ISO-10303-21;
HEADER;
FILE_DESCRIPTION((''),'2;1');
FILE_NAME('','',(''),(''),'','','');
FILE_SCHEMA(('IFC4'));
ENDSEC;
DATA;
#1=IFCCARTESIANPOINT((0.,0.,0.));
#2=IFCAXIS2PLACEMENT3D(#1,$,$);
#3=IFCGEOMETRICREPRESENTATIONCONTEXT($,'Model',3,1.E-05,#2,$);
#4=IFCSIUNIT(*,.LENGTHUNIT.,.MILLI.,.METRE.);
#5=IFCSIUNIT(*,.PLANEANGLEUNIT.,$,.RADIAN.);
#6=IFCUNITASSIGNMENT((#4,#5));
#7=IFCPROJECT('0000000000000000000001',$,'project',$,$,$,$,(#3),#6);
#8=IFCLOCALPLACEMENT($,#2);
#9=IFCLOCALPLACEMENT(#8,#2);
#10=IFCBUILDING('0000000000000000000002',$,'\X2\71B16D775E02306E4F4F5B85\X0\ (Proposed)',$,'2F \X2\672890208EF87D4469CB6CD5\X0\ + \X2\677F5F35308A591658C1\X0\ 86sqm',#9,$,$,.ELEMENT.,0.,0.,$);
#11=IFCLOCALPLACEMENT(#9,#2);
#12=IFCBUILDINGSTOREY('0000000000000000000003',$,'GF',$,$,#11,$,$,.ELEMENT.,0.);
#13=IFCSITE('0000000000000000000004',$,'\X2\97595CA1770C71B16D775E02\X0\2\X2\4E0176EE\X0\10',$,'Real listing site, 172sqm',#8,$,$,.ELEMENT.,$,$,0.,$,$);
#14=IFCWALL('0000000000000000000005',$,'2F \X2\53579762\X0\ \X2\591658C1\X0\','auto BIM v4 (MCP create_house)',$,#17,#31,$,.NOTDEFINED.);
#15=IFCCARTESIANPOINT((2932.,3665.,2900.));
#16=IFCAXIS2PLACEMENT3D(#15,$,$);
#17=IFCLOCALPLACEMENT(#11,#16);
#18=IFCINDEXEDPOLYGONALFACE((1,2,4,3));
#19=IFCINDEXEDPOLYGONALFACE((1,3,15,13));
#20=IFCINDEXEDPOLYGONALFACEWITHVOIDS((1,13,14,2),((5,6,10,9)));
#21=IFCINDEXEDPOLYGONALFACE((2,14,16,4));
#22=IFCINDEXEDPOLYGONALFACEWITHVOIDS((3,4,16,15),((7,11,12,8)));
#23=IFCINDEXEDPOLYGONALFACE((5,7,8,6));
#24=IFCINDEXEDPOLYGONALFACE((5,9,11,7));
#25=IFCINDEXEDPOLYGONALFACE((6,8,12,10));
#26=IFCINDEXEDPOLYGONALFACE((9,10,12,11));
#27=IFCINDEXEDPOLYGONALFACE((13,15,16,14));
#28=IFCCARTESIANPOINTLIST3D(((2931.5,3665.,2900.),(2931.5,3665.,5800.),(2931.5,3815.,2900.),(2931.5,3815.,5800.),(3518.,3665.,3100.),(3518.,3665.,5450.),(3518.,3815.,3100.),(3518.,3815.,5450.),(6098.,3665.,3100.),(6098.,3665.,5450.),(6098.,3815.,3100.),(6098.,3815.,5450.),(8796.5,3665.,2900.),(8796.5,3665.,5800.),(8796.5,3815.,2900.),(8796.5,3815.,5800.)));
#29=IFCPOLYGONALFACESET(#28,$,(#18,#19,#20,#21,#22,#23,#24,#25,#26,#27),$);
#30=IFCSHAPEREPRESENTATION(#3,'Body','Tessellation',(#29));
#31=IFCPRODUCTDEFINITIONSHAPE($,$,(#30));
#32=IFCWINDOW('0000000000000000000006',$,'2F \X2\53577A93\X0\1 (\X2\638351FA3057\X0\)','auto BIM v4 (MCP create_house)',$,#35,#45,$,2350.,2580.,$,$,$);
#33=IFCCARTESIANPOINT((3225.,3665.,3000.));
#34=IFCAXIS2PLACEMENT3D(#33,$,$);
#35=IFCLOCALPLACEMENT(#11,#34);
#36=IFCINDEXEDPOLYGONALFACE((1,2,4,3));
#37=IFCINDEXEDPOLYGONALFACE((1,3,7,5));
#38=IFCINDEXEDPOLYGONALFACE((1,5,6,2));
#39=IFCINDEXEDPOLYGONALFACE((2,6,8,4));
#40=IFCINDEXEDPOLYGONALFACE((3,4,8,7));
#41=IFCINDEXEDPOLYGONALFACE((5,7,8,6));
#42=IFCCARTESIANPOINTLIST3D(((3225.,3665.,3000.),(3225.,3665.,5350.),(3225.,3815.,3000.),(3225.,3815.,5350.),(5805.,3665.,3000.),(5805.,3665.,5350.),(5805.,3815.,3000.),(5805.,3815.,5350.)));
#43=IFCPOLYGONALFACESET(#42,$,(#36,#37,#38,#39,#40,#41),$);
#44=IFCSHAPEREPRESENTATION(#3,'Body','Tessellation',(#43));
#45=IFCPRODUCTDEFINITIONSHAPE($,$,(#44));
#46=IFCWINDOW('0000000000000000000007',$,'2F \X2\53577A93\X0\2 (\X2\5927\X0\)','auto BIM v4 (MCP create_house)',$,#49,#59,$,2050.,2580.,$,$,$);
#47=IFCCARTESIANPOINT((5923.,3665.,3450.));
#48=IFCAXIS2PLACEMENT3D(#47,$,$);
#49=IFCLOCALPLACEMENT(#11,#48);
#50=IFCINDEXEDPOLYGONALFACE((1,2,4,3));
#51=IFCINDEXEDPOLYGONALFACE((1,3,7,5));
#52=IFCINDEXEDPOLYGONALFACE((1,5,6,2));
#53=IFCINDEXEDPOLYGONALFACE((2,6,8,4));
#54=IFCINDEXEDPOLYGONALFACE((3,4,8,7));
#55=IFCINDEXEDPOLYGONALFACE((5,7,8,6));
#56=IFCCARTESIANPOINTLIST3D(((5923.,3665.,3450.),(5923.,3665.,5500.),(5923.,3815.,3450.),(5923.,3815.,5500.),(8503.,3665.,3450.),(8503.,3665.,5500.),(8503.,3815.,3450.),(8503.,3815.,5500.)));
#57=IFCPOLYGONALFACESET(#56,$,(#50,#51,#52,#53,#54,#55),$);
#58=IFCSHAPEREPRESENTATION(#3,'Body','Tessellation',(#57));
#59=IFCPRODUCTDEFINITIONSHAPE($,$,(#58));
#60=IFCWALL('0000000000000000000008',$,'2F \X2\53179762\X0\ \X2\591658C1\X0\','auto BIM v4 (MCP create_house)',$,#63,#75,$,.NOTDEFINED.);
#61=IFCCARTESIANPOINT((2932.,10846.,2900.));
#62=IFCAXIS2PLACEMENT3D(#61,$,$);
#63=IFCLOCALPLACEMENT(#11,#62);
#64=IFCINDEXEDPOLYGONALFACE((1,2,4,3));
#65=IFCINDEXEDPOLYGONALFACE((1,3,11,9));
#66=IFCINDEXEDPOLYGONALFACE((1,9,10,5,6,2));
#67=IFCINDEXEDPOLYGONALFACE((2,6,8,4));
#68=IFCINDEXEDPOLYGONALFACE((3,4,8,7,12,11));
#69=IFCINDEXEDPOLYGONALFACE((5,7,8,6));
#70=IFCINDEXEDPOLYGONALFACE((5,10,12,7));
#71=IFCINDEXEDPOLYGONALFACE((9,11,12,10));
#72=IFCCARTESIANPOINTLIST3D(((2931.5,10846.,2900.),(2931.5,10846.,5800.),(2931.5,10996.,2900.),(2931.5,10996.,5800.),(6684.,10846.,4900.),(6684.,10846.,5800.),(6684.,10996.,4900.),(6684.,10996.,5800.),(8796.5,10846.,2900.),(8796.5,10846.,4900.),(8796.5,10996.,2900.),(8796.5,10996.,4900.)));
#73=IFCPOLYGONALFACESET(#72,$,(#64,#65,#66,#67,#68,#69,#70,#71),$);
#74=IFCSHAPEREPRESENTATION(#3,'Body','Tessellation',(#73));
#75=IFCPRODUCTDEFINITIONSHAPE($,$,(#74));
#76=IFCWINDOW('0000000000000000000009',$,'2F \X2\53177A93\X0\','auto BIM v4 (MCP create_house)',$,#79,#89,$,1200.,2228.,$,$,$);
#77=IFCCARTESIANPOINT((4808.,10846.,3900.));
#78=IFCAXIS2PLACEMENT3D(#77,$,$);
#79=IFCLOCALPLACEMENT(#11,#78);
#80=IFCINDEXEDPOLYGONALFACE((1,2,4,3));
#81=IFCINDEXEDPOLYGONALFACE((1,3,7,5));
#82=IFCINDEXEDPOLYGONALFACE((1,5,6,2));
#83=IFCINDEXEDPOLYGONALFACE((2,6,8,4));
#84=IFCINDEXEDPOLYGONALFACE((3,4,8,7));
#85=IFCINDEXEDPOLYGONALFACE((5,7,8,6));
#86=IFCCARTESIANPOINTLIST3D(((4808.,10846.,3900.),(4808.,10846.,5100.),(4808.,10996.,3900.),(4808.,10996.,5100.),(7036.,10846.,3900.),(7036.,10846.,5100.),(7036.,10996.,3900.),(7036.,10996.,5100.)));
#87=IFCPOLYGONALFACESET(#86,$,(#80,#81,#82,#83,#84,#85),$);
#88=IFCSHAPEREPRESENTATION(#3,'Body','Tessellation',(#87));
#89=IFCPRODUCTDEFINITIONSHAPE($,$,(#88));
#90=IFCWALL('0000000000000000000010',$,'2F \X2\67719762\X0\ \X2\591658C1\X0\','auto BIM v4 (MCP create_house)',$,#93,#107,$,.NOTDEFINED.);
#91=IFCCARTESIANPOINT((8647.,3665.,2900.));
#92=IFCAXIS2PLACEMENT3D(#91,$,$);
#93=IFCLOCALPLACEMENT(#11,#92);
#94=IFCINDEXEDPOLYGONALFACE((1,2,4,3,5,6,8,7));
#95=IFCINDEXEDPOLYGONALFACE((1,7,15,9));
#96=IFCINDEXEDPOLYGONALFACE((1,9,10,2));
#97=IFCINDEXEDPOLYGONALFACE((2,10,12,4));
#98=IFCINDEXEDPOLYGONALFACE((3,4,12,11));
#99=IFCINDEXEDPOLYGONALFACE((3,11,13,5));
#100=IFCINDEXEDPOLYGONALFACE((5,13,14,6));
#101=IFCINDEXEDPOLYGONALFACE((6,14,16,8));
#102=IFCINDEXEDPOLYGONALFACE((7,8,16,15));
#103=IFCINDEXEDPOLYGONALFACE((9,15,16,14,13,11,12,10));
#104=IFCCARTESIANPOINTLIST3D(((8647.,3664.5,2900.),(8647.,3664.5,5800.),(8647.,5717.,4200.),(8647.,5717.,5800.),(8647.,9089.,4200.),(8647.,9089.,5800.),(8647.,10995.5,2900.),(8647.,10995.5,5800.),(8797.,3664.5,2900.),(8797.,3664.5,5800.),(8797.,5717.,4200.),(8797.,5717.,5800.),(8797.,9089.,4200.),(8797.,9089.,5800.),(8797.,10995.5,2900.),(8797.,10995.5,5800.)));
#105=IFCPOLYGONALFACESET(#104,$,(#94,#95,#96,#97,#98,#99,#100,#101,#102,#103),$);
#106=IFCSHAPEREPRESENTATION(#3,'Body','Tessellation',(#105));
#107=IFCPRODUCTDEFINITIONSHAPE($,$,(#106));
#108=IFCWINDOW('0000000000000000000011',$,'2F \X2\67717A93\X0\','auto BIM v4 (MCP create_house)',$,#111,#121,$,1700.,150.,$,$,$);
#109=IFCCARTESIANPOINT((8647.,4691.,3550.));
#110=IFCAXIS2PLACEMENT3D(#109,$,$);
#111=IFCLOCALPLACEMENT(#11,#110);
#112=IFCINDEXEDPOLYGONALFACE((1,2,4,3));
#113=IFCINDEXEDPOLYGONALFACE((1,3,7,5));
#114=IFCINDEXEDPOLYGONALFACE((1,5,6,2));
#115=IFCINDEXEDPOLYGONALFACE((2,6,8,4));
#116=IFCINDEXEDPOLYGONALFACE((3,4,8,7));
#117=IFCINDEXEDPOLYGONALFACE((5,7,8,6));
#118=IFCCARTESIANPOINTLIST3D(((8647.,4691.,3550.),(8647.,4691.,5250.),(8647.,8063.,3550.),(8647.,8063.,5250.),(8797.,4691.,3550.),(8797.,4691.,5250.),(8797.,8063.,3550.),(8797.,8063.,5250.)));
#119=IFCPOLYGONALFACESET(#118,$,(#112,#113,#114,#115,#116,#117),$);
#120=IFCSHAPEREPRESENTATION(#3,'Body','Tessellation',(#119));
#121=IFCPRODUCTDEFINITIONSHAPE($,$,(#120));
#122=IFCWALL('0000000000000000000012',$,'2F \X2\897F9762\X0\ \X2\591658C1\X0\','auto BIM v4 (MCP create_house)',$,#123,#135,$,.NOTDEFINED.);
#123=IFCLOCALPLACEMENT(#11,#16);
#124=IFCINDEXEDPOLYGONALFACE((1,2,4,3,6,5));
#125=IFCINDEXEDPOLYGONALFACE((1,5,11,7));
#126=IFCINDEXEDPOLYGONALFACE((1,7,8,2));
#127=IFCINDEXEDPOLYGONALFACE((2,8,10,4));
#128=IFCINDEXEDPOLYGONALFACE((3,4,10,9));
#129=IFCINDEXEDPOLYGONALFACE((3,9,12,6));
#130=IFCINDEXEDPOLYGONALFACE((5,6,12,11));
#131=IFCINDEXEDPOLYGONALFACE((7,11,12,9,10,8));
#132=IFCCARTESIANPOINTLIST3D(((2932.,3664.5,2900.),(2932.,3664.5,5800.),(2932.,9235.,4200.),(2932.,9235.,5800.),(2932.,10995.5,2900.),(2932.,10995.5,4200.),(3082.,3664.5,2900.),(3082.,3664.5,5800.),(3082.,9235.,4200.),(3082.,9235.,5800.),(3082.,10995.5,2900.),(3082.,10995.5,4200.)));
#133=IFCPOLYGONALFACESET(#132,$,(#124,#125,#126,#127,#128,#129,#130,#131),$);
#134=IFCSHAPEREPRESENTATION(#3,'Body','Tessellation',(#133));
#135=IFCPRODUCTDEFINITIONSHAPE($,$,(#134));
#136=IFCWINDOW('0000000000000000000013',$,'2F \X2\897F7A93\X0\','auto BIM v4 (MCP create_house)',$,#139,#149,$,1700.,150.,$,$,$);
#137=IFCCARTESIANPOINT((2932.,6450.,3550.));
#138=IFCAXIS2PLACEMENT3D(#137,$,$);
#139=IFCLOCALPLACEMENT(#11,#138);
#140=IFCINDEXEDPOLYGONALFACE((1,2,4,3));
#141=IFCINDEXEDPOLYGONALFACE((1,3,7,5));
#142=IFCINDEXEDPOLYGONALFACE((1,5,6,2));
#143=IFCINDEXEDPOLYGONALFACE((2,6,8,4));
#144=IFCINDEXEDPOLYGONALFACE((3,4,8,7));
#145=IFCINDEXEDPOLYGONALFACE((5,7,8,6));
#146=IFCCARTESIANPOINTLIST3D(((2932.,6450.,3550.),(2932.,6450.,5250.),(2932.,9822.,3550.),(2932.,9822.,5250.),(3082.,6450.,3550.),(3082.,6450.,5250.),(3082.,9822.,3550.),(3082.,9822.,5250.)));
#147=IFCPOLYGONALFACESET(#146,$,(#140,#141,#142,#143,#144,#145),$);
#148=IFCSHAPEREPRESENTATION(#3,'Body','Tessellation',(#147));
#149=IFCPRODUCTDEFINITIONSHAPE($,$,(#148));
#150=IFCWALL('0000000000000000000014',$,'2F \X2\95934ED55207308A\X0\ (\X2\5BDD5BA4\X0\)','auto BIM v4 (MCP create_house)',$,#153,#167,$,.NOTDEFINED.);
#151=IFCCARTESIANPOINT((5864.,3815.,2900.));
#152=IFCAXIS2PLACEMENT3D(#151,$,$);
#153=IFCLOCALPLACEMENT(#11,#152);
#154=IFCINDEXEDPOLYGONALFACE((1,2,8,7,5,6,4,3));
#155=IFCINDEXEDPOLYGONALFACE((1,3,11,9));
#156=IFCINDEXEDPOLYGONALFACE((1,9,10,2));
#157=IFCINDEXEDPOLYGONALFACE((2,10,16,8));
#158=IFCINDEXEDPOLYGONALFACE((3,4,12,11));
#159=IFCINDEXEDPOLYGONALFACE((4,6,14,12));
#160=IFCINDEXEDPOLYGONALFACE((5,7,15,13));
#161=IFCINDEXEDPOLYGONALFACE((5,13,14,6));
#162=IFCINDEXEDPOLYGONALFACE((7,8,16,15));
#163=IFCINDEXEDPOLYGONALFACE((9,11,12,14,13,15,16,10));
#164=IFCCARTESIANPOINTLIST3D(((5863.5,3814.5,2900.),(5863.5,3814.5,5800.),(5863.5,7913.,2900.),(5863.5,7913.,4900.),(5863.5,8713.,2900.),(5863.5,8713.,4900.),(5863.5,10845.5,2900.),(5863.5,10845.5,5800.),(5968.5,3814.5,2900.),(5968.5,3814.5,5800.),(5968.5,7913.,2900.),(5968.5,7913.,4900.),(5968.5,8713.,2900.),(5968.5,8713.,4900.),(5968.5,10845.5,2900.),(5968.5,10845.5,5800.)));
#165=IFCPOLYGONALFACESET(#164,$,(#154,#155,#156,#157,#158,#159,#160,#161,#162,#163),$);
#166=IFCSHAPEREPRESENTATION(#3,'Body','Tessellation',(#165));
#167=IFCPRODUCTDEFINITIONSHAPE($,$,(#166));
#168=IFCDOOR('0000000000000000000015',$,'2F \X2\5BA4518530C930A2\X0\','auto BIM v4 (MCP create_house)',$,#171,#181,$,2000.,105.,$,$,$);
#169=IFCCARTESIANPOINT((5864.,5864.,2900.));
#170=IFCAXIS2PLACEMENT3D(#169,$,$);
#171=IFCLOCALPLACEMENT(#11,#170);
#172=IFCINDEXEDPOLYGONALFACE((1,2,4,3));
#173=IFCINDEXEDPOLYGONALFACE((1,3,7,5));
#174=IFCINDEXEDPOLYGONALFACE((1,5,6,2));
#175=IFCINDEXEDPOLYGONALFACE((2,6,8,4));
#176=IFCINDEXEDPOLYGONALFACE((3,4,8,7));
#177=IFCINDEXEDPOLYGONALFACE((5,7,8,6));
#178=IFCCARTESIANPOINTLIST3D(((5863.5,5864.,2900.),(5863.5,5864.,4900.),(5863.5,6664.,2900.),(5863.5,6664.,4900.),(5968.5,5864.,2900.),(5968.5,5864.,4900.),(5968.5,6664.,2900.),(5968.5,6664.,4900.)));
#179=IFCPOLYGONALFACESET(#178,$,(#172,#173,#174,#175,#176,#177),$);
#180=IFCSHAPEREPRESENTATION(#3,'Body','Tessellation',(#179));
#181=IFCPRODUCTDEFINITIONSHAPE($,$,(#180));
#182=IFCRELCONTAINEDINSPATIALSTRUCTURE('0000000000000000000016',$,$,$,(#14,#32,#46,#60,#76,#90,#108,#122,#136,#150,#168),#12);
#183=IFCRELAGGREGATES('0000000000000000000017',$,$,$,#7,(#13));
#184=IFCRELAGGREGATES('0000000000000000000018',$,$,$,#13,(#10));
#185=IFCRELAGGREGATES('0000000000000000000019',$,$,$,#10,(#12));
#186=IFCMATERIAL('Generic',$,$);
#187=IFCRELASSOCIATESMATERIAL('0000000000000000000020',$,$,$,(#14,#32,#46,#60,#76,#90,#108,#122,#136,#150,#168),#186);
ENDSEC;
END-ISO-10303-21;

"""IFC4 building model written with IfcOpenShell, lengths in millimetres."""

from ifc_helpers import new_model, si_unit, frame, frame_2d, origin, place, context, project, spatial, rectangle, extrude, material, element, fill, save


model = new_model("IFC4")

# Units and contexts
model_context = context("Model", 3, precision=1e-05, world=origin())
ifc_project = project(units=[si_unit("LENGTHUNIT", "METRE", prefix="MILLI"), si_unit("PLANEANGLEUNIT", "RADIAN")], contexts=[model_context])

# Site, building, storey
site_placement = place(None, origin())
site = spatial("IfcSite", under=ifc_project, at=site_placement, Name="静岡県熱海市2丁目10", ObjectType="Real listing site, 172sqm", CompositionType="ELEMENT", RefElevation=0.0)
building_placement = place(site_placement, origin())
building = spatial("IfcBuilding", under=site, at=building_placement, Name="熱海市の住宅 (Proposed)", ObjectType="2F 木造軸組構法 + 板張り外壁 86sqm", CompositionType="ELEMENT", ElevationOfRefHeight=0.0, ElevationOfTerrain=0.0)
storey_placement = place(building_placement, origin())
storey = spatial("IfcBuildingStorey", under=building, at=storey_placement, Name="GF", CompositionType="ELEMENT", Elevation=0.0)

# Shared definitions
ifc_material = material(Name="Generic")

# Wall, openings, windows
wall_1_placement = place(storey_placement, frame((2932.0, 3665.0, 2900.0)))
wall_1 = element("IfcWall", 1, at=wall_1_placement, inside=storey, material=ifc_material, Name="2F 南面 外壁", Description="auto BIM v4 (MCP create_house)", PredefinedType="NOTDEFINED", context=model_context, shape_type="SweptSolid", body=[
    extrude(rectangle(XDim=5865.0, YDim=150.0, at=frame_2d((2932.0, 75.0))), frame((2932.0, 3665.0, 2900.0)), (0.0, 0.0, 1.0), 2900.0),
])
opening_1_placement = place(storey_placement, frame((3225.0, 3665.0, 3000.0)))
opening_1 = element("IfcOpeningElement", 2, at=opening_1_placement, cuts=wall_1, PredefinedType="NOTDEFINED", context=model_context, shape_type="SweptSolid", body=[
    extrude(rectangle(XDim=2580.0, YDim=150.0, at=frame_2d((1290.0, 75.0))), frame((3225.0, 3665.0, 3000.0)), (0.0, 0.0, 1.0), 2350.0),
])
opening_2_placement = place(storey_placement, frame((5923.0, 3665.0, 3450.0)))
opening_2 = element("IfcOpeningElement", 3, at=opening_2_placement, cuts=wall_1, PredefinedType="NOTDEFINED", context=model_context, shape_type="SweptSolid", body=[
    extrude(rectangle(XDim=2580.0, YDim=150.0, at=frame_2d((1290.0, 75.0))), frame((5923.0, 3665.0, 3450.0)), (0.0, 0.0, 1.0), 2050.0),
])
window_1_placement = place(storey_placement, frame((3225.0, 3665.0, 3000.0)))
window_1 = element("IfcWindow", 4, at=window_1_placement, inside=storey, material=ifc_material, Name="2F 南窓1 (掃出し)", Description="auto BIM v4 (MCP create_house)", OverallHeight=2350.0, OverallWidth=2580.0, context=model_context, shape_type="SweptSolid", body=[
    extrude(rectangle(XDim=2580.0, YDim=150.0, at=frame_2d((1290.0, 75.0))), frame((3225.0, 3665.0, 3000.0)), (0.0, 0.0, 1.0), 2350.0),
])
fill(opening_1, window_1)
window_2_placement = place(storey_placement, frame((5923.0, 3665.0, 3450.0)))
window_2 = element("IfcWindow", 5, at=window_2_placement, inside=storey, material=ifc_material, Name="2F 南窓2 (大)", Description="auto BIM v4 (MCP create_house)", OverallHeight=2050.0, OverallWidth=2580.0, context=model_context, shape_type="SweptSolid", body=[
    extrude(rectangle(XDim=2580.0, YDim=150.0, at=frame_2d((1290.0, 75.0))), frame((5923.0, 3665.0, 3450.0)), (0.0, 0.0, 1.0), 2050.0),
])
fill(opening_2, window_2)

# Walls, openings, windows
wall_2_placement = place(storey_placement, frame((2932.0, 10846.0, 2900.0)))
wall_2 = element("IfcWall", 6, at=wall_2_placement, inside=storey, material=ifc_material, Name="2F 北面 外壁", Description="auto BIM v4 (MCP create_house)", PredefinedType="NOTDEFINED", context=model_context, shape_type="SweptSolid", body=[
    extrude(rectangle(XDim=5865.0, YDim=150.0, at=frame_2d((2932.0, 75.0))), frame((2932.0, 10846.0, 2900.0)), (0.0, 0.0, 1.0), 2900.0),
])
opening_3_placement = place(storey_placement, frame((4808.0, 10846.0, 3900.0)))
opening_3 = element("IfcOpeningElement", 7, at=opening_3_placement, cuts=wall_2, PredefinedType="NOTDEFINED", context=model_context, shape_type="SweptSolid", body=[
    extrude(rectangle(XDim=2228.0, YDim=150.0, at=frame_2d((1114.0, 75.0))), frame((4808.0, 10846.0, 3900.0)), (0.0, 0.0, 1.0), 1200.0),
])
window_3_placement = place(storey_placement, frame((4808.0, 10846.0, 3900.0)))
window_3 = element("IfcWindow", 8, at=window_3_placement, inside=storey, material=ifc_material, Name="2F 北窓", Description="auto BIM v4 (MCP create_house)", OverallHeight=1200.0, OverallWidth=2228.0, context=model_context, shape_type="SweptSolid", body=[
    extrude(rectangle(XDim=2228.0, YDim=150.0, at=frame_2d((1114.0, 75.0))), frame((4808.0, 10846.0, 3900.0)), (0.0, 0.0, 1.0), 1200.0),
])
fill(opening_3, window_3)
wall_3_placement = place(storey_placement, frame((8647.0, 3665.0, 2900.0)))
wall_3 = element("IfcWall", 9, at=wall_3_placement, inside=storey, material=ifc_material, Name="2F 東面 外壁", Description="auto BIM v4 (MCP create_house)", PredefinedType="NOTDEFINED", context=model_context, shape_type="SweptSolid", body=[
    extrude(rectangle(XDim=150.0, YDim=7331.0, at=frame_2d((75.0, 3665.0))), frame((8647.0, 3665.0, 2900.0)), (0.0, 0.0, 1.0), 2900.0),
])
opening_4_placement = place(storey_placement, frame((8647.0, 4691.0, 3550.0)))
opening_4 = element("IfcOpeningElement", 10, at=opening_4_placement, cuts=wall_3, PredefinedType="NOTDEFINED", context=model_context, shape_type="SweptSolid", body=[
    extrude(rectangle(XDim=150.0, YDim=3372.0, at=frame_2d((75.0, 1686.0))), frame((8647.0, 4691.0, 3550.0)), (0.0, 0.0, 1.0), 1700.0),
])
window_4_placement = place(storey_placement, frame((8647.0, 4691.0, 3550.0)))
window_4 = element("IfcWindow", 11, at=window_4_placement, inside=storey, material=ifc_material, Name="2F 東窓", Description="auto BIM v4 (MCP create_house)", OverallHeight=1700.0, OverallWidth=150.0, context=model_context, shape_type="SweptSolid", body=[
    extrude(rectangle(XDim=150.0, YDim=3372.0, at=frame_2d((75.0, 1686.0))), frame((8647.0, 4691.0, 3550.0)), (0.0, 0.0, 1.0), 1700.0),
])
fill(opening_4, window_4)
wall_4_placement = place(storey_placement, frame((2932.0, 3665.0, 2900.0)))
wall_4 = element("IfcWall", 12, at=wall_4_placement, inside=storey, material=ifc_material, Name="2F 西面 外壁", Description="auto BIM v4 (MCP create_house)", PredefinedType="NOTDEFINED", context=model_context, shape_type="SweptSolid", body=[
    extrude(rectangle(XDim=150.0, YDim=7331.0, at=frame_2d((75.0, 3665.0))), frame((2932.0, 3665.0, 2900.0)), (0.0, 0.0, 1.0), 2900.0),
])
opening_5_placement = place(storey_placement, frame((2932.0, 6450.0, 3550.0)))
opening_5 = element("IfcOpeningElement", 13, at=opening_5_placement, cuts=wall_4, PredefinedType="NOTDEFINED", context=model_context, shape_type="SweptSolid", body=[
    extrude(rectangle(XDim=150.0, YDim=3372.0, at=frame_2d((75.0, 1686.0))), frame((2932.0, 6450.0, 3550.0)), (0.0, 0.0, 1.0), 1700.0),
])
window_5_placement = place(storey_placement, frame((2932.0, 6450.0, 3550.0)))
window_5 = element("IfcWindow", 14, at=window_5_placement, inside=storey, material=ifc_material, Name="2F 西窓", Description="auto BIM v4 (MCP create_house)", OverallHeight=1700.0, OverallWidth=150.0, context=model_context, shape_type="SweptSolid", body=[
    extrude(rectangle(XDim=150.0, YDim=3372.0, at=frame_2d((75.0, 1686.0))), frame((2932.0, 6450.0, 3550.0)), (0.0, 0.0, 1.0), 1700.0),
])
fill(opening_5, window_5)

# Wall, opening, door
wall_5_placement = place(storey_placement, frame((5864.0, 3815.0, 2900.0)))
wall_5 = element("IfcWall", 15, at=wall_5_placement, inside=storey, material=ifc_material, Name="2F 間仕切り (寝室)", Description="auto BIM v4 (MCP create_house)", PredefinedType="NOTDEFINED", context=model_context, shape_type="SweptSolid", body=[
    extrude(rectangle(XDim=105.0, YDim=7031.0, at=frame_2d((52.0, 3515.0))), frame((5864.0, 3815.0, 2900.0)), (0.0, 0.0, 1.0), 2900.0),
])
opening_6_placement = place(storey_placement, frame((5864.0, 5864.0, 2900.0)))
opening_6 = element("IfcOpeningElement", 16, at=opening_6_placement, cuts=wall_5, PredefinedType="NOTDEFINED", context=model_context, shape_type="SweptSolid", body=[
    extrude(rectangle(XDim=105.0, YDim=800.0, at=frame_2d((52.0, 400.0))), frame((5864.0, 5864.0, 2900.0)), (0.0, 0.0, 1.0), 2000.0),
])
door_1_placement = place(storey_placement, frame((5864.0, 5864.0, 2900.0)))
door_1 = element("IfcDoor", 17, at=door_1_placement, inside=storey, material=ifc_material, Name="2F 室内ドア", Description="auto BIM v4 (MCP create_house)", OverallHeight=2000.0, OverallWidth=105.0, context=model_context, shape_type="SweptSolid", body=[
    extrude(rectangle(XDim=105.0, YDim=800.0, at=frame_2d((52.0, 400.0))), frame((5864.0, 5864.0, 2900.0)), (0.0, 0.0, 1.0), 2000.0),
])
fill(opening_6, door_1)

save(model, "model.ifc")
